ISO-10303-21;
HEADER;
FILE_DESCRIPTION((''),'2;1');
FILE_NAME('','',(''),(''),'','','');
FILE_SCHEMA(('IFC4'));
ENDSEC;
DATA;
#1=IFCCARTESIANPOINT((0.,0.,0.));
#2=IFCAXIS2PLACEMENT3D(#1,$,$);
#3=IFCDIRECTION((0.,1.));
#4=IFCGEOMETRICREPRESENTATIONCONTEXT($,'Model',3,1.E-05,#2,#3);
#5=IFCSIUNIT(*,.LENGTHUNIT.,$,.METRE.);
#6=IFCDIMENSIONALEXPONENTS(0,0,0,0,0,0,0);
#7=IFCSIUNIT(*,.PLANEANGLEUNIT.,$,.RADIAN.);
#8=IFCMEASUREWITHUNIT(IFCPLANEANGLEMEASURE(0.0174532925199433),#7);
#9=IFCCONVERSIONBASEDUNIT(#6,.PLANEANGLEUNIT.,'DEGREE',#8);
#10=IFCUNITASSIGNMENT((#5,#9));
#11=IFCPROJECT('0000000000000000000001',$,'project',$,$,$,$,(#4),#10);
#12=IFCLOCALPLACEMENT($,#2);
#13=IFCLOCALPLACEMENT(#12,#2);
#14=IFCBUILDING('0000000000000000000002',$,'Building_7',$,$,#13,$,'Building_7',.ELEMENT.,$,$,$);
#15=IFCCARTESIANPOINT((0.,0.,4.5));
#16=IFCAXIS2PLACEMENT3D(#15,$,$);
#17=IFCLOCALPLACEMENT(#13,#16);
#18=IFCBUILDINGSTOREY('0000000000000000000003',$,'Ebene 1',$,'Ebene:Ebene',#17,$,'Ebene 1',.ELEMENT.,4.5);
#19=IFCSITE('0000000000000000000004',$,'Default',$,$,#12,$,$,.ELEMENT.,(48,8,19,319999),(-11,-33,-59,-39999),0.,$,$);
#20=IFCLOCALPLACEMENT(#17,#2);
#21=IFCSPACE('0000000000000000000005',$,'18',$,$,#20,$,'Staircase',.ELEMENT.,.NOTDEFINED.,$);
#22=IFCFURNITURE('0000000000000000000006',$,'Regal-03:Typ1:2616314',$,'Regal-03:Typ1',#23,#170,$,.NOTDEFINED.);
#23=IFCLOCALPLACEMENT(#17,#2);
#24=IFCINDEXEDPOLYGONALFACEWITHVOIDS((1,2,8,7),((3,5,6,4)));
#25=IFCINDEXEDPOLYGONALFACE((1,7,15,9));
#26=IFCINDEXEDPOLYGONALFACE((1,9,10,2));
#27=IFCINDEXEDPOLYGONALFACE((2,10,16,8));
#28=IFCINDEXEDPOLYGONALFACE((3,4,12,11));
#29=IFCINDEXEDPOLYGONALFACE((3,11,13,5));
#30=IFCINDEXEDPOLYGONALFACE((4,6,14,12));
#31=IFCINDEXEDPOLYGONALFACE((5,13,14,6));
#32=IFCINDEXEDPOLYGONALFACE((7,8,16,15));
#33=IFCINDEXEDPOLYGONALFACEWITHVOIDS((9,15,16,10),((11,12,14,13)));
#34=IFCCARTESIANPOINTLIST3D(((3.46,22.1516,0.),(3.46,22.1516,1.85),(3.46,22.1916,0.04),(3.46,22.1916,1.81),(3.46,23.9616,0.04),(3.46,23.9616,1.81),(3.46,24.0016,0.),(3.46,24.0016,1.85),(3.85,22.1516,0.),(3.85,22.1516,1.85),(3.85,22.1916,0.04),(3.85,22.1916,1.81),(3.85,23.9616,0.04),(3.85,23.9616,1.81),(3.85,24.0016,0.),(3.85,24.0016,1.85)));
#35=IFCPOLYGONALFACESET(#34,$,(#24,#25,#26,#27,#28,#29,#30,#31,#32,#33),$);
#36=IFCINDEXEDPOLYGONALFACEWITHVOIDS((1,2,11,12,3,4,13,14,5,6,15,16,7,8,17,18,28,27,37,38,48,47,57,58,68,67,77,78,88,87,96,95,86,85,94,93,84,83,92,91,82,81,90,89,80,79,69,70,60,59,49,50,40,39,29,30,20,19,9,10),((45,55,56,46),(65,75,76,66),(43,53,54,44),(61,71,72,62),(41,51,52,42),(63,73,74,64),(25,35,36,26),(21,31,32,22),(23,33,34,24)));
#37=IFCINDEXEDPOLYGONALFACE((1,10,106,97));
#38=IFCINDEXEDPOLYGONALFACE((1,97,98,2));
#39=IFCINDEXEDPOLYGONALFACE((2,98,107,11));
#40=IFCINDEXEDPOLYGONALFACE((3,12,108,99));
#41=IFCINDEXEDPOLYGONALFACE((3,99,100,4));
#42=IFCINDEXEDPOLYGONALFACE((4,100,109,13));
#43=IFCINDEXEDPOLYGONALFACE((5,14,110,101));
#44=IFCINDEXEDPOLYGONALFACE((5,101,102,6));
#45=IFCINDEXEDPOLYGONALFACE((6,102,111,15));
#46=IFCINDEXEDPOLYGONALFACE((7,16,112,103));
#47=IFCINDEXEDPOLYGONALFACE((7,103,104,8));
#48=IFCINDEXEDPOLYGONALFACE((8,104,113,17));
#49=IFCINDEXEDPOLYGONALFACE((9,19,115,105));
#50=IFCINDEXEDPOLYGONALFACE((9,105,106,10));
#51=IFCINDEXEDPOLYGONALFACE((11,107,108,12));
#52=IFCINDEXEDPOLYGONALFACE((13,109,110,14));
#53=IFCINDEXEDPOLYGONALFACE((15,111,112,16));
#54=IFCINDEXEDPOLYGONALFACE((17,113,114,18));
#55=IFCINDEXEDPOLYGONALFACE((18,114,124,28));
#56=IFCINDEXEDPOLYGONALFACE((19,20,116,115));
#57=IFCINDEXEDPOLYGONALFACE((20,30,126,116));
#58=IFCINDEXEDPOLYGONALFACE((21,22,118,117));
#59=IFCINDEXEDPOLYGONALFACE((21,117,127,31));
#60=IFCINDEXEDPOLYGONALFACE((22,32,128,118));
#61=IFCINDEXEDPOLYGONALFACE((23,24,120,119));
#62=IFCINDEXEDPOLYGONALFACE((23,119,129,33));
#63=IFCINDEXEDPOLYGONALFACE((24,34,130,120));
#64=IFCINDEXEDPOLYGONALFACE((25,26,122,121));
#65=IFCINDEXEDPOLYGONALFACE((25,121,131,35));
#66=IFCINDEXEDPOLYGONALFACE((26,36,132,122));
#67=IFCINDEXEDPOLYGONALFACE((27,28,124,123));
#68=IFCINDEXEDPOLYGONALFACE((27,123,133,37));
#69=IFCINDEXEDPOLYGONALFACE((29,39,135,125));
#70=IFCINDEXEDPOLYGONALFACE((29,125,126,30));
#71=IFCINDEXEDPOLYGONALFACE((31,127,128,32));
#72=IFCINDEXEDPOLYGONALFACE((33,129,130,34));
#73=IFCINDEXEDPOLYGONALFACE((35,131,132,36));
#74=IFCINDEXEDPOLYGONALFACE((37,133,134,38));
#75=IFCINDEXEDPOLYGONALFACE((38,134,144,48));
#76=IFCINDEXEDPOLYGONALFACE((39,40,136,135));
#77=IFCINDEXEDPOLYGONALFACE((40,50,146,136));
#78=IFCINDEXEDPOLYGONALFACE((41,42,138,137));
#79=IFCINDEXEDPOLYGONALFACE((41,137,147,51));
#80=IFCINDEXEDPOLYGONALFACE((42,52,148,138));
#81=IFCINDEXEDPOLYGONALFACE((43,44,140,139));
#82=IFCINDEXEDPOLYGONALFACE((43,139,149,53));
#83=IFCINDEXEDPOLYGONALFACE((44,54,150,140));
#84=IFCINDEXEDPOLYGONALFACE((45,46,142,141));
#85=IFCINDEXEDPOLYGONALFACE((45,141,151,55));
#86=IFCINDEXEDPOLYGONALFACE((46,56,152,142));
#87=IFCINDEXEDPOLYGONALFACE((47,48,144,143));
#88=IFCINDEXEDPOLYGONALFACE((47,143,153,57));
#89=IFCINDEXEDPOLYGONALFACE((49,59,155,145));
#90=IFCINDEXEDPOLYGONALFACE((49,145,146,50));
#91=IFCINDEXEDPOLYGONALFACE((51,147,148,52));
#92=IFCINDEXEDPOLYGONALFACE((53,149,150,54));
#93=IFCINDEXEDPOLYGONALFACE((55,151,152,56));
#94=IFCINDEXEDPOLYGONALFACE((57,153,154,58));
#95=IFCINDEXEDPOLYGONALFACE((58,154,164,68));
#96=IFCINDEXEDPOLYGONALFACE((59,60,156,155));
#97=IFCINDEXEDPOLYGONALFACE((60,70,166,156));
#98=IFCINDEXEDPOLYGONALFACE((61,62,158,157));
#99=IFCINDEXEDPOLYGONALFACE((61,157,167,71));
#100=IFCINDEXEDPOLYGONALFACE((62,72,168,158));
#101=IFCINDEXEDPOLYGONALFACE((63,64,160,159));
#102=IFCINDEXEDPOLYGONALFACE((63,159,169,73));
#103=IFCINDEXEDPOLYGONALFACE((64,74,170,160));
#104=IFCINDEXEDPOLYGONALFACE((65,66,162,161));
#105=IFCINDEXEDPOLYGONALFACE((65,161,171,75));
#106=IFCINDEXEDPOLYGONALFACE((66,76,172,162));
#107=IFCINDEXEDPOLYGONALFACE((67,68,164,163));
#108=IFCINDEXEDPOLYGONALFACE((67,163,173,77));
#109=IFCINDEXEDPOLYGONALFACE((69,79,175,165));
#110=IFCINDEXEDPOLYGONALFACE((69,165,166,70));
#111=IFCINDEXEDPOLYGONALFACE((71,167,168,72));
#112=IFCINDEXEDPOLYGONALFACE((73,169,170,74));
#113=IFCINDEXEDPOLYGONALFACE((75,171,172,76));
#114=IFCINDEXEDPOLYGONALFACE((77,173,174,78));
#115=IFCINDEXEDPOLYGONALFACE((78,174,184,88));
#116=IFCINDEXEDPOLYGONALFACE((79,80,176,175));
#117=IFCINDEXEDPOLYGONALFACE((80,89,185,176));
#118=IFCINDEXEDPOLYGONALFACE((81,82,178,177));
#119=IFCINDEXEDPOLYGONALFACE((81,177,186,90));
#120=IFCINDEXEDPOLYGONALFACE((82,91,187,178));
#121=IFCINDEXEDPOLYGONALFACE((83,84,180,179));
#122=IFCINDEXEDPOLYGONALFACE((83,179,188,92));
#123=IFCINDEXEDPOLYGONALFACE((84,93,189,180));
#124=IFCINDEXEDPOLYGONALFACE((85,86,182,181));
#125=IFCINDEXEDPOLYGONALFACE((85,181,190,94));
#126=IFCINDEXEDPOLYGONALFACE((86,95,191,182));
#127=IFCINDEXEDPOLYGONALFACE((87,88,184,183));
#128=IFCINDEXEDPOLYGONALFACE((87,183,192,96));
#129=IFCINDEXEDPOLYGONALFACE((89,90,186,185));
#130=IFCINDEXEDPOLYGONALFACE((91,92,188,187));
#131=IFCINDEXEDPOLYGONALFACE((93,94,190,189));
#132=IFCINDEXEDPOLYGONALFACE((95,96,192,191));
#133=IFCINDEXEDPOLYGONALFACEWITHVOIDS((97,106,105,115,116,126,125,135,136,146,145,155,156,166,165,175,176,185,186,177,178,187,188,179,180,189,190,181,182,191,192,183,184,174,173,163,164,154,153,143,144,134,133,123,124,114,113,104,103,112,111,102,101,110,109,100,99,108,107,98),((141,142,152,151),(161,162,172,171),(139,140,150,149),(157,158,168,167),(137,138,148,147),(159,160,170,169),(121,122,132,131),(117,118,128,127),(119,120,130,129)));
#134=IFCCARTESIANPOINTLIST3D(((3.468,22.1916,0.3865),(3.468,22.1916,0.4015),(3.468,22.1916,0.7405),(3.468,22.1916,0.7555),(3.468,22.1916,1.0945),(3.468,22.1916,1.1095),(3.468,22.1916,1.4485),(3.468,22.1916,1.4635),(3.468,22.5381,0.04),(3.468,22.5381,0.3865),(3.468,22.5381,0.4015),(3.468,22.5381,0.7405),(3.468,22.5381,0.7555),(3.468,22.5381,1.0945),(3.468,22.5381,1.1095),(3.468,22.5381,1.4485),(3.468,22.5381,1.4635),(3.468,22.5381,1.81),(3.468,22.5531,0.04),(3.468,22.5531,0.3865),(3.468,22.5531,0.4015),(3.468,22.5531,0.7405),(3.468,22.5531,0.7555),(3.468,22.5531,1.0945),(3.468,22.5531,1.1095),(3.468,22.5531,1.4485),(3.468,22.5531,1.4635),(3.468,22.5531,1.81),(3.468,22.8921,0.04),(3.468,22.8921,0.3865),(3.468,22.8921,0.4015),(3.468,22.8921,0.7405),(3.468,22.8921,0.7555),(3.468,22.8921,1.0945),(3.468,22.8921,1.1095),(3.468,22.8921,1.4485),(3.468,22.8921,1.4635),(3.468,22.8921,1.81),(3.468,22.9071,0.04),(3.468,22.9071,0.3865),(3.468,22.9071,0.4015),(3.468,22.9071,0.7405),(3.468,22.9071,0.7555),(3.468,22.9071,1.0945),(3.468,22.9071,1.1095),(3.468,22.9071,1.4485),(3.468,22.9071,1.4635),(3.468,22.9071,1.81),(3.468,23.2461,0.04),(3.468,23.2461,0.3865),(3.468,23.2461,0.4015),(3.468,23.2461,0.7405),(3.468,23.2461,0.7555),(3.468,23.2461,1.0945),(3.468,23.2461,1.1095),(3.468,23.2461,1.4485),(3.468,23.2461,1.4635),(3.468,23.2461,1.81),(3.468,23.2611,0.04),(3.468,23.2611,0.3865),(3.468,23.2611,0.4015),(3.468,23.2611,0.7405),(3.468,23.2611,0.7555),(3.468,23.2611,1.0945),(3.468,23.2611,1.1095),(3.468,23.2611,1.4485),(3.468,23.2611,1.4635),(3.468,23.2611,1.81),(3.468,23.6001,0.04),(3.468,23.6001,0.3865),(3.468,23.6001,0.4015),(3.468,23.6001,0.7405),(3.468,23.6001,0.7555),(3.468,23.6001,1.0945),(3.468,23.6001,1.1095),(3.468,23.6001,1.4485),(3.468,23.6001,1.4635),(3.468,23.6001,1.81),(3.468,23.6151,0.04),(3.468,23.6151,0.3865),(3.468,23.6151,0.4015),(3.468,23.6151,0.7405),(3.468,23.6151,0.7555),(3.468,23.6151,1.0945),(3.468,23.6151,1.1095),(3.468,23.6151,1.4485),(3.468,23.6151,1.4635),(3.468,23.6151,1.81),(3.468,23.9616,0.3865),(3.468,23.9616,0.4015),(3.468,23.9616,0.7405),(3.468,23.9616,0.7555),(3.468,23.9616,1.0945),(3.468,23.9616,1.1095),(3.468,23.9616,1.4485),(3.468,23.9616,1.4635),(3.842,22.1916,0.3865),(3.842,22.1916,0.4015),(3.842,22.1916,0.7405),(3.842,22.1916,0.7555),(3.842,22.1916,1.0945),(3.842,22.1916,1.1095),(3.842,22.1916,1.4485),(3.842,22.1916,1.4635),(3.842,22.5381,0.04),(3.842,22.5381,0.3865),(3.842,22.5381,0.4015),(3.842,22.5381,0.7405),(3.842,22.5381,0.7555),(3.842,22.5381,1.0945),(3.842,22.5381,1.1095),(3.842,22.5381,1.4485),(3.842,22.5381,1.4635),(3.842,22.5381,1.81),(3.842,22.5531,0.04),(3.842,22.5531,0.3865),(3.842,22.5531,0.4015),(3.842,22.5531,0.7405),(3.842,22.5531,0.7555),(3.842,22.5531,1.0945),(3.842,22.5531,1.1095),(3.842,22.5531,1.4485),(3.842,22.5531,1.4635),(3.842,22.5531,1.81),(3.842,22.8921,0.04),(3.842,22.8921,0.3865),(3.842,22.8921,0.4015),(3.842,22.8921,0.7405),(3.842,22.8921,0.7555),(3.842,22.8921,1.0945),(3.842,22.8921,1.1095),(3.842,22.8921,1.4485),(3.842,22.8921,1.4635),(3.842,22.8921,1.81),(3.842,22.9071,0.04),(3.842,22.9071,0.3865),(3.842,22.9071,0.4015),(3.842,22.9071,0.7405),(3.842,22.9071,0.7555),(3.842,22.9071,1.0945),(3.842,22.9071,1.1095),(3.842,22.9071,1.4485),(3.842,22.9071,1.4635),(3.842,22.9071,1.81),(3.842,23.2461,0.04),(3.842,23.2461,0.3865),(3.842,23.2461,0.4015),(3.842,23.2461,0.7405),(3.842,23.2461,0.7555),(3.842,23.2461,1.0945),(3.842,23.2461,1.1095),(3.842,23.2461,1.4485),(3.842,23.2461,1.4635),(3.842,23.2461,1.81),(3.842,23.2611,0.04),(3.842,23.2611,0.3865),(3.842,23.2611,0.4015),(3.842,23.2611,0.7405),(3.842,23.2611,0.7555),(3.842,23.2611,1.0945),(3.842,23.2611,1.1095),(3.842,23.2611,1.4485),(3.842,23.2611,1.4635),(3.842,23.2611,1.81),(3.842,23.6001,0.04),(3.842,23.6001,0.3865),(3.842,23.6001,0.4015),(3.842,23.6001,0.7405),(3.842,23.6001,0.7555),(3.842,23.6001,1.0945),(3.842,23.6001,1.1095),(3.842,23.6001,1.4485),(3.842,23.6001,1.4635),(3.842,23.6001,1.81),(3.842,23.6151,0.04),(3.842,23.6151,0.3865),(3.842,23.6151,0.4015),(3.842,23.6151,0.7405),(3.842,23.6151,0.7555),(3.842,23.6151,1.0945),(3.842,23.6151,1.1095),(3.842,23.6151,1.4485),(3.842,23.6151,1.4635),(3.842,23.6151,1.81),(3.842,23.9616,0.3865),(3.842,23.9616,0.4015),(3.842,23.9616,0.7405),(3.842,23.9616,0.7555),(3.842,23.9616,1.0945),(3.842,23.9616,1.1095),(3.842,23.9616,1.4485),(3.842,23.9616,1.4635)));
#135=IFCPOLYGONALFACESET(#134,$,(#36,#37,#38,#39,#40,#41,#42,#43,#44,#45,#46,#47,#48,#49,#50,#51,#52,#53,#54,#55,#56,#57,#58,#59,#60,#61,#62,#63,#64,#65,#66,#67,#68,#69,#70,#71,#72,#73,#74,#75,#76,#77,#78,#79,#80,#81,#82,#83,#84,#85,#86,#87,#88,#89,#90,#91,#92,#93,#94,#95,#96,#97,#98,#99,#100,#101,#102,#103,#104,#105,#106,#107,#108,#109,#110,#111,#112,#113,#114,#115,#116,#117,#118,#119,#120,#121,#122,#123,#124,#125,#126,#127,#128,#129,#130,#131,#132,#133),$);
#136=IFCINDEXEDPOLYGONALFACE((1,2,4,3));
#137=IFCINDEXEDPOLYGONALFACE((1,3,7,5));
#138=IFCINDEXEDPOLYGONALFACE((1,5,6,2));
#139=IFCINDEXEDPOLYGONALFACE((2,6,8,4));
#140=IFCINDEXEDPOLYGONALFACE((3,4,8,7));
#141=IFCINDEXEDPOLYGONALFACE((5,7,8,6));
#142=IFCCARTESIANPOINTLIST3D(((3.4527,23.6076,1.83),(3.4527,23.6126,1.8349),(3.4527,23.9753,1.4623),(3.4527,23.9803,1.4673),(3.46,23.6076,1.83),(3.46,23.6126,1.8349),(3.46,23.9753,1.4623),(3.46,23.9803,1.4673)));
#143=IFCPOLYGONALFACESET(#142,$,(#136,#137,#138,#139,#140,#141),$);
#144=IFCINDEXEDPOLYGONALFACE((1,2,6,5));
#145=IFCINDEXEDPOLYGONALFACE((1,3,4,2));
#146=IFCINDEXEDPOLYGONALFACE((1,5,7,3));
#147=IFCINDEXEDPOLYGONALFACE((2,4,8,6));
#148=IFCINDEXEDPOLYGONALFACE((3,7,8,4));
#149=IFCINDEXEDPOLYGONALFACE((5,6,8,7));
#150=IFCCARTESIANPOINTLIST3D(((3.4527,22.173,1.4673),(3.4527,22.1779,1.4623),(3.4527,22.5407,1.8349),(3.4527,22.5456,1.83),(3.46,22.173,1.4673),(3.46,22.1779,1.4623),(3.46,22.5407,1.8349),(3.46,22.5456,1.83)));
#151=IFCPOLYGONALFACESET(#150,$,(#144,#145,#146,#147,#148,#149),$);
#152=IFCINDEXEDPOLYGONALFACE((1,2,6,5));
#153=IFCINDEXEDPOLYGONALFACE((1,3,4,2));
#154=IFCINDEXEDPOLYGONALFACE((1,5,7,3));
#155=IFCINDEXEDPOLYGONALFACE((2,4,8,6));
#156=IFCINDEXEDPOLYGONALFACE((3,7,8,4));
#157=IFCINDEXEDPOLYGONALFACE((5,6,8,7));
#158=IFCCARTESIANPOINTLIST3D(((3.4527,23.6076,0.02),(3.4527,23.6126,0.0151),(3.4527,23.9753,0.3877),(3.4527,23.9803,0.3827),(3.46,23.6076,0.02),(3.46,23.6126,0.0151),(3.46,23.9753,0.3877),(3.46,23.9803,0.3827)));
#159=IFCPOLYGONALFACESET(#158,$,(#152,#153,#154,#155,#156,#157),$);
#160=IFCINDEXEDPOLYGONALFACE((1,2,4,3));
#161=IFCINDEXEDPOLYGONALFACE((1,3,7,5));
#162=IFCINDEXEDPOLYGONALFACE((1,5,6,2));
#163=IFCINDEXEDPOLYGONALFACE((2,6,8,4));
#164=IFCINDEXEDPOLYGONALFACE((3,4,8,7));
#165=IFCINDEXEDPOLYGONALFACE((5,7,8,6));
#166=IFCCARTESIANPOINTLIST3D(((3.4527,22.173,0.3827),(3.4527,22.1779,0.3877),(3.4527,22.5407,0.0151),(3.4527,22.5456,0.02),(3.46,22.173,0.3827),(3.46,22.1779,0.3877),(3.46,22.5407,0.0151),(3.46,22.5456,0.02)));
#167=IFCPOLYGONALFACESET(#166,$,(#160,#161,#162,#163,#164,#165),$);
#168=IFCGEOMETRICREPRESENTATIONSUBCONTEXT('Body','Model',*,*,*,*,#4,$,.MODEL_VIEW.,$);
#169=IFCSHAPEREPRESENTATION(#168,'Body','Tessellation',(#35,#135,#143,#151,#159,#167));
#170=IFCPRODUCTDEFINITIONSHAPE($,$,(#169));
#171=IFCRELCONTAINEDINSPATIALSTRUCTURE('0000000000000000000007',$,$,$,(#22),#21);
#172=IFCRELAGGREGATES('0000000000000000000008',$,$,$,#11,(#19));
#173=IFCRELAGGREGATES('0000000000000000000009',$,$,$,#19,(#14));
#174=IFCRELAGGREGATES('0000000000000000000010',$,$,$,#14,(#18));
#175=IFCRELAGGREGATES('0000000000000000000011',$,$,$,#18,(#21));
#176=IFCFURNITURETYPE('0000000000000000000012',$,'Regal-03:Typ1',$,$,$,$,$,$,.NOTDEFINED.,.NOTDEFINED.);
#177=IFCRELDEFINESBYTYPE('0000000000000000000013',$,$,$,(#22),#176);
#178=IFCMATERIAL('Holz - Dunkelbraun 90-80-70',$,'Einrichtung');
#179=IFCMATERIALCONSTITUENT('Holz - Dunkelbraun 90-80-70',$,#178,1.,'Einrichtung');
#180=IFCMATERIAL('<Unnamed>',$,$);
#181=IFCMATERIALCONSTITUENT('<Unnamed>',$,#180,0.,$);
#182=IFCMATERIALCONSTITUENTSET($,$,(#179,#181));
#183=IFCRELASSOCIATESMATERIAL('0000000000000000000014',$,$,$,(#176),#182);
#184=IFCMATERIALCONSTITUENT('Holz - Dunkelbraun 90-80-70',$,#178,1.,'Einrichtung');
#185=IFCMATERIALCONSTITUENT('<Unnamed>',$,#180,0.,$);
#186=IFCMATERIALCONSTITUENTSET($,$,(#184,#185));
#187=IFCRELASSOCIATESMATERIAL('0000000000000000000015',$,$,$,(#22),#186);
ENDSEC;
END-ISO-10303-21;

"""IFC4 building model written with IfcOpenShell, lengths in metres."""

from ifc_helpers import new_model, entity, si_unit, converted_unit, direction, frame, origin, place, context, subcontext, project, spatial, indexed_curve, outline, extrude, source, transform, mapped, material, constituent, constituent_set, type_object, type_shapes, element, save


model = new_model("IFC4")

# Units and contexts
model_context = context("Model", 3, precision=1e-05, world=origin(), true_north=direction((0.0, 1.0)))
body_context = subcontext(model_context, "Body", "Model", "MODEL_VIEW")
ifc_project = project(units=[si_unit("LENGTHUNIT", "METRE"), converted_unit("PLANEANGLEUNIT", "DEGREE", entity("IfcPlaneAngleMeasure", 0.0174532925199433), si_unit("PLANEANGLEUNIT", "RADIAN"), dimensions=[0, 0, 0, 0, 0, 0, 0])], contexts=[model_context])

# Site, building, storey
site_placement = place(None, origin())
site = spatial("IfcSite", under=ifc_project, at=site_placement, Name="Default", CompositionType="ELEMENT", RefLatitude=(48, 8, 19, 319999), RefLongitude=(-11, -33, -59, -39999), RefElevation=0.0)
building_placement = place(site_placement, origin())
building = spatial("IfcBuilding", under=site, at=building_placement, Name="Building_7", LongName="Building_7", CompositionType="ELEMENT")
storey_placement = place(building_placement, frame((0.0, 0.0, 4.5)))
storey = spatial("IfcBuildingStorey", under=building, at=storey_placement, Name="Ebene 1", ObjectType="Ebene:Ebene", LongName="Ebene 1", CompositionType="ELEMENT", Elevation=4.5)

# Shared definitions
ifc_material_1 = material(Name="<Unnamed>")

# Shared definitions
ifc_material_2 = material(Name="Holz - Dunkelbraun 90-80-70", Category="Einrichtung")
ifc_constituent_1 = constituent(ifc_material_2, Name="Holz - Dunkelbraun 90-80-70", Category="Einrichtung", fraction=1.0)
ifc_constituent_2 = constituent(ifc_material_1, Name="<Unnamed>", fraction=0.0)
ifc_constituent_set_1 = constituent_set(constituents=[ifc_constituent_1, ifc_constituent_2])
furniture_type_1 = type_object("IfcFurnitureType", Name="Regal-03:Typ1", AssemblyPlace="NOTDEFINED", PredefinedType="NOTDEFINED", material=ifc_constituent_set_1)
shared_shape_1 = source(origin(), body_context, "Body", "SweptSolid", [
    extrude(outline(indexed_curve([(-0.925, -0.925), (0.925, -0.925), (0.925, 0.925), (-0.925, 0.925), (-0.925, -0.925)], self_intersect=False), holes=[indexed_curve([(-0.885, -0.885), (-0.885, 0.885), (0.885, 0.885), (0.885, -0.885), (-0.885, -0.885)], self_intersect=False)]), frame((0.2471, -0.2651, 0.925), z_axis=(0.0, 1.0, 0.0), x_axis=(0.0, 0.0, -1.0)), (0.0, 0.0, 1.0), 0.39),
    extrude(outline(indexed_curve([(0.5385, -0.5385), (0.885, -0.5385), (0.885, -0.5235), (0.5385, -0.5235), (0.5385, -0.1845), (0.885, -0.1845), (0.885, -0.1695), (0.5385, -0.1695), (0.5385, 0.1695), (0.885, 0.1695), (0.885, 0.1845), (0.5385, 0.1845), (0.5385, 0.5235), (0.885, 0.5235), (0.885, 0.5385), (0.5385, 0.5385), (0.5385, 0.885), (0.5235, 0.885), (0.5235, 0.5385), (0.1845, 0.5385), (0.1845, 0.885), (0.1695, 0.885), (0.1695, 0.5385), (-0.1695, 0.5385), (-0.1695, 0.885), (-0.1845, 0.885), (-0.1845, 0.5385), (-0.5235, 0.5385), (-0.5235, 0.885), (-0.5385, 0.885), (-0.5385, 0.5385), (-0.885, 0.5385), (-0.885, 0.5235), (-0.5385, 0.5235), (-0.5385, 0.1845), (-0.885, 0.1845), (-0.885, 0.1695), (-0.5385, 0.1695), (-0.5385, -0.1695), (-0.885, -0.1695), (-0.885, -0.1845), (-0.5385, -0.1845), (-0.5385, -0.5235), (-0.885, -0.5235), (-0.885, -0.5385), (-0.5385, -0.5385), (-0.5385, -0.885), (-0.5235, -0.885), (-0.5235, -0.5385), (-0.1845, -0.5385), (-0.1845, -0.885), (-0.1695, -0.885), (-0.1695, -0.5385), (0.1695, -0.5385), (0.1695, -0.885), (0.1845, -0.885), (0.1845, -0.5385), (0.5235, -0.5385), (0.5235, -0.885), (0.5385, -0.885), (0.5385, -0.5385)], self_intersect=False), holes=[indexed_curve([(0.5235, -0.1845), (0.5235, -0.5235), (0.1845, -0.5235), (0.1845, -0.1845), (0.5235, -0.1845)], self_intersect=False), indexed_curve([(0.1845, -0.1695), (0.1845, 0.1695), (0.5235, 0.1695), (0.5235, -0.1695), (0.1845, -0.1695)], self_intersect=False), indexed_curve([(0.1845, 0.1845), (0.1845, 0.5235), (0.5235, 0.5235), (0.5235, 0.1845), (0.1845, 0.1845)], self_intersect=False), indexed_curve([(-0.1695, 0.5235), (0.1695, 0.5235), (0.1695, 0.1845), (-0.1695, 0.1845), (-0.1695, 0.5235)], self_intersect=False), indexed_curve([(-0.1695, 0.1695), (0.1695, 0.1695), (0.1695, -0.1695), (-0.1695, -0.1695), (-0.1695, 0.1695)], self_intersect=False), indexed_curve([(-0.1695, -0.1845), (0.1695, -0.1845), (0.1695, -0.5235), (-0.1695, -0.5235), (-0.1695, -0.1845)], self_intersect=False), indexed_curve([(-0.5235, -0.5235), (-0.5235, -0.1845), (-0.1845, -0.1845), (-0.1845, -0.5235), (-0.5235, -0.5235)], self_intersect=False), indexed_curve([(-0.5235, -0.1695), (-0.5235, 0.1695), (-0.1845, 0.1695), (-0.1845, -0.1695), (-0.5235, -0.1695)], self_intersect=False), indexed_curve([(-0.5235, 0.1845), (-0.5235, 0.5235), (-0.1845, 0.5235), (-0.1845, 0.1845), (-0.5235, 0.1845)], self_intersect=False)]), frame((0.2471, -0.2571, 0.925), z_axis=(0.0, 1.0, 0.0), x_axis=(0.0, 0.0, 1.0)), (0.0, 0.0, 1.0), 0.374),
    extrude(outline(indexed_curve([(-0.0037, -0.0035), (0.0037, -0.0035), (0.0037, 0.0035), (-0.0037, 0.0035), (-0.0037, -0.0035)], self_intersect=False)), frame((1.1482, 0.1286, 1.4648), z_axis=(-0.707107, 0.0, 0.707107), x_axis=(0.0, 1.0, 0.0)), (0.0, 0.0, 1.0), 0.52),
    extrude(outline(indexed_curve([(-0.0037, -0.0035), (0.0037, -0.0035), (0.0037, 0.0035), (-0.0037, 0.0035), (-0.0037, -0.0035)], self_intersect=False)), frame((-0.6541, 0.1286, 1.4648), z_axis=(0.707107, 0.0, 0.707107), x_axis=(0.0, 1.0, 0.0)), (0.0, 0.0, 1.0), 0.52),
    extrude(outline(indexed_curve([(-0.0037, -0.0035), (0.0037, -0.0035), (0.0037, 0.0035), (-0.0037, 0.0035), (-0.0037, -0.0035)], self_intersect=False)), frame((0.7805, 0.1286, 0.0175), z_axis=(0.707107, 0.0, 0.707107), x_axis=(0.0, 1.0, 0.0)), (0.0, 0.0, 1.0), 0.52),
    extrude(outline(indexed_curve([(-0.0037, -0.0035), (0.0037, -0.0035), (0.0037, 0.0035), (-0.0037, 0.0035), (-0.0037, -0.0035)], self_intersect=False)), frame((-0.2864, 0.1286, 0.0175), z_axis=(-0.707107, 0.0, 0.707107), x_axis=(0.0, 1.0, 0.0)), (0.0, 0.0, 1.0), 0.52),
])
type_shapes(furniture_type_1, [shared_shape_1])

# Shared definitions
space_1_placement = place(storey_placement, origin())
space_1 = spatial("IfcSpace", under=storey, at=space_1_placement, Name="18", LongName="Staircase", CompositionType="ELEMENT", PredefinedType="NOTDEFINED")

# Furniture
ifc_constituent_3 = constituent(ifc_material_2, Name="Holz - Dunkelbraun 90-80-70", Category="Einrichtung", fraction=1.0)
ifc_constituent_4 = constituent(ifc_material_1, Name="<Unnamed>", fraction=0.0)
ifc_constituent_set_2 = constituent_set(constituents=[ifc_constituent_3, ifc_constituent_4])
furniture_1_placement = place(space_1_placement, frame((3.5849, 22.8296, 0.0), z_axis=(0.0, 0.0, 1.0), x_axis=(0.0, 1.0, 0.0)))
element("IfcFurniture", 1, at=furniture_1_placement, inside=space_1, type_object=furniture_type_1, material=ifc_constituent_set_2, Name="Regal-03:Typ1:2616314", ObjectType="Regal-03:Typ1", PredefinedType="NOTDEFINED", context=body_context, shape_type="MappedRepresentation", body=[
    mapped(shared_shape_1, transform((0.0, 0.0, 0.0), scale=1.0)),
])

save(model, "model.ifc")
